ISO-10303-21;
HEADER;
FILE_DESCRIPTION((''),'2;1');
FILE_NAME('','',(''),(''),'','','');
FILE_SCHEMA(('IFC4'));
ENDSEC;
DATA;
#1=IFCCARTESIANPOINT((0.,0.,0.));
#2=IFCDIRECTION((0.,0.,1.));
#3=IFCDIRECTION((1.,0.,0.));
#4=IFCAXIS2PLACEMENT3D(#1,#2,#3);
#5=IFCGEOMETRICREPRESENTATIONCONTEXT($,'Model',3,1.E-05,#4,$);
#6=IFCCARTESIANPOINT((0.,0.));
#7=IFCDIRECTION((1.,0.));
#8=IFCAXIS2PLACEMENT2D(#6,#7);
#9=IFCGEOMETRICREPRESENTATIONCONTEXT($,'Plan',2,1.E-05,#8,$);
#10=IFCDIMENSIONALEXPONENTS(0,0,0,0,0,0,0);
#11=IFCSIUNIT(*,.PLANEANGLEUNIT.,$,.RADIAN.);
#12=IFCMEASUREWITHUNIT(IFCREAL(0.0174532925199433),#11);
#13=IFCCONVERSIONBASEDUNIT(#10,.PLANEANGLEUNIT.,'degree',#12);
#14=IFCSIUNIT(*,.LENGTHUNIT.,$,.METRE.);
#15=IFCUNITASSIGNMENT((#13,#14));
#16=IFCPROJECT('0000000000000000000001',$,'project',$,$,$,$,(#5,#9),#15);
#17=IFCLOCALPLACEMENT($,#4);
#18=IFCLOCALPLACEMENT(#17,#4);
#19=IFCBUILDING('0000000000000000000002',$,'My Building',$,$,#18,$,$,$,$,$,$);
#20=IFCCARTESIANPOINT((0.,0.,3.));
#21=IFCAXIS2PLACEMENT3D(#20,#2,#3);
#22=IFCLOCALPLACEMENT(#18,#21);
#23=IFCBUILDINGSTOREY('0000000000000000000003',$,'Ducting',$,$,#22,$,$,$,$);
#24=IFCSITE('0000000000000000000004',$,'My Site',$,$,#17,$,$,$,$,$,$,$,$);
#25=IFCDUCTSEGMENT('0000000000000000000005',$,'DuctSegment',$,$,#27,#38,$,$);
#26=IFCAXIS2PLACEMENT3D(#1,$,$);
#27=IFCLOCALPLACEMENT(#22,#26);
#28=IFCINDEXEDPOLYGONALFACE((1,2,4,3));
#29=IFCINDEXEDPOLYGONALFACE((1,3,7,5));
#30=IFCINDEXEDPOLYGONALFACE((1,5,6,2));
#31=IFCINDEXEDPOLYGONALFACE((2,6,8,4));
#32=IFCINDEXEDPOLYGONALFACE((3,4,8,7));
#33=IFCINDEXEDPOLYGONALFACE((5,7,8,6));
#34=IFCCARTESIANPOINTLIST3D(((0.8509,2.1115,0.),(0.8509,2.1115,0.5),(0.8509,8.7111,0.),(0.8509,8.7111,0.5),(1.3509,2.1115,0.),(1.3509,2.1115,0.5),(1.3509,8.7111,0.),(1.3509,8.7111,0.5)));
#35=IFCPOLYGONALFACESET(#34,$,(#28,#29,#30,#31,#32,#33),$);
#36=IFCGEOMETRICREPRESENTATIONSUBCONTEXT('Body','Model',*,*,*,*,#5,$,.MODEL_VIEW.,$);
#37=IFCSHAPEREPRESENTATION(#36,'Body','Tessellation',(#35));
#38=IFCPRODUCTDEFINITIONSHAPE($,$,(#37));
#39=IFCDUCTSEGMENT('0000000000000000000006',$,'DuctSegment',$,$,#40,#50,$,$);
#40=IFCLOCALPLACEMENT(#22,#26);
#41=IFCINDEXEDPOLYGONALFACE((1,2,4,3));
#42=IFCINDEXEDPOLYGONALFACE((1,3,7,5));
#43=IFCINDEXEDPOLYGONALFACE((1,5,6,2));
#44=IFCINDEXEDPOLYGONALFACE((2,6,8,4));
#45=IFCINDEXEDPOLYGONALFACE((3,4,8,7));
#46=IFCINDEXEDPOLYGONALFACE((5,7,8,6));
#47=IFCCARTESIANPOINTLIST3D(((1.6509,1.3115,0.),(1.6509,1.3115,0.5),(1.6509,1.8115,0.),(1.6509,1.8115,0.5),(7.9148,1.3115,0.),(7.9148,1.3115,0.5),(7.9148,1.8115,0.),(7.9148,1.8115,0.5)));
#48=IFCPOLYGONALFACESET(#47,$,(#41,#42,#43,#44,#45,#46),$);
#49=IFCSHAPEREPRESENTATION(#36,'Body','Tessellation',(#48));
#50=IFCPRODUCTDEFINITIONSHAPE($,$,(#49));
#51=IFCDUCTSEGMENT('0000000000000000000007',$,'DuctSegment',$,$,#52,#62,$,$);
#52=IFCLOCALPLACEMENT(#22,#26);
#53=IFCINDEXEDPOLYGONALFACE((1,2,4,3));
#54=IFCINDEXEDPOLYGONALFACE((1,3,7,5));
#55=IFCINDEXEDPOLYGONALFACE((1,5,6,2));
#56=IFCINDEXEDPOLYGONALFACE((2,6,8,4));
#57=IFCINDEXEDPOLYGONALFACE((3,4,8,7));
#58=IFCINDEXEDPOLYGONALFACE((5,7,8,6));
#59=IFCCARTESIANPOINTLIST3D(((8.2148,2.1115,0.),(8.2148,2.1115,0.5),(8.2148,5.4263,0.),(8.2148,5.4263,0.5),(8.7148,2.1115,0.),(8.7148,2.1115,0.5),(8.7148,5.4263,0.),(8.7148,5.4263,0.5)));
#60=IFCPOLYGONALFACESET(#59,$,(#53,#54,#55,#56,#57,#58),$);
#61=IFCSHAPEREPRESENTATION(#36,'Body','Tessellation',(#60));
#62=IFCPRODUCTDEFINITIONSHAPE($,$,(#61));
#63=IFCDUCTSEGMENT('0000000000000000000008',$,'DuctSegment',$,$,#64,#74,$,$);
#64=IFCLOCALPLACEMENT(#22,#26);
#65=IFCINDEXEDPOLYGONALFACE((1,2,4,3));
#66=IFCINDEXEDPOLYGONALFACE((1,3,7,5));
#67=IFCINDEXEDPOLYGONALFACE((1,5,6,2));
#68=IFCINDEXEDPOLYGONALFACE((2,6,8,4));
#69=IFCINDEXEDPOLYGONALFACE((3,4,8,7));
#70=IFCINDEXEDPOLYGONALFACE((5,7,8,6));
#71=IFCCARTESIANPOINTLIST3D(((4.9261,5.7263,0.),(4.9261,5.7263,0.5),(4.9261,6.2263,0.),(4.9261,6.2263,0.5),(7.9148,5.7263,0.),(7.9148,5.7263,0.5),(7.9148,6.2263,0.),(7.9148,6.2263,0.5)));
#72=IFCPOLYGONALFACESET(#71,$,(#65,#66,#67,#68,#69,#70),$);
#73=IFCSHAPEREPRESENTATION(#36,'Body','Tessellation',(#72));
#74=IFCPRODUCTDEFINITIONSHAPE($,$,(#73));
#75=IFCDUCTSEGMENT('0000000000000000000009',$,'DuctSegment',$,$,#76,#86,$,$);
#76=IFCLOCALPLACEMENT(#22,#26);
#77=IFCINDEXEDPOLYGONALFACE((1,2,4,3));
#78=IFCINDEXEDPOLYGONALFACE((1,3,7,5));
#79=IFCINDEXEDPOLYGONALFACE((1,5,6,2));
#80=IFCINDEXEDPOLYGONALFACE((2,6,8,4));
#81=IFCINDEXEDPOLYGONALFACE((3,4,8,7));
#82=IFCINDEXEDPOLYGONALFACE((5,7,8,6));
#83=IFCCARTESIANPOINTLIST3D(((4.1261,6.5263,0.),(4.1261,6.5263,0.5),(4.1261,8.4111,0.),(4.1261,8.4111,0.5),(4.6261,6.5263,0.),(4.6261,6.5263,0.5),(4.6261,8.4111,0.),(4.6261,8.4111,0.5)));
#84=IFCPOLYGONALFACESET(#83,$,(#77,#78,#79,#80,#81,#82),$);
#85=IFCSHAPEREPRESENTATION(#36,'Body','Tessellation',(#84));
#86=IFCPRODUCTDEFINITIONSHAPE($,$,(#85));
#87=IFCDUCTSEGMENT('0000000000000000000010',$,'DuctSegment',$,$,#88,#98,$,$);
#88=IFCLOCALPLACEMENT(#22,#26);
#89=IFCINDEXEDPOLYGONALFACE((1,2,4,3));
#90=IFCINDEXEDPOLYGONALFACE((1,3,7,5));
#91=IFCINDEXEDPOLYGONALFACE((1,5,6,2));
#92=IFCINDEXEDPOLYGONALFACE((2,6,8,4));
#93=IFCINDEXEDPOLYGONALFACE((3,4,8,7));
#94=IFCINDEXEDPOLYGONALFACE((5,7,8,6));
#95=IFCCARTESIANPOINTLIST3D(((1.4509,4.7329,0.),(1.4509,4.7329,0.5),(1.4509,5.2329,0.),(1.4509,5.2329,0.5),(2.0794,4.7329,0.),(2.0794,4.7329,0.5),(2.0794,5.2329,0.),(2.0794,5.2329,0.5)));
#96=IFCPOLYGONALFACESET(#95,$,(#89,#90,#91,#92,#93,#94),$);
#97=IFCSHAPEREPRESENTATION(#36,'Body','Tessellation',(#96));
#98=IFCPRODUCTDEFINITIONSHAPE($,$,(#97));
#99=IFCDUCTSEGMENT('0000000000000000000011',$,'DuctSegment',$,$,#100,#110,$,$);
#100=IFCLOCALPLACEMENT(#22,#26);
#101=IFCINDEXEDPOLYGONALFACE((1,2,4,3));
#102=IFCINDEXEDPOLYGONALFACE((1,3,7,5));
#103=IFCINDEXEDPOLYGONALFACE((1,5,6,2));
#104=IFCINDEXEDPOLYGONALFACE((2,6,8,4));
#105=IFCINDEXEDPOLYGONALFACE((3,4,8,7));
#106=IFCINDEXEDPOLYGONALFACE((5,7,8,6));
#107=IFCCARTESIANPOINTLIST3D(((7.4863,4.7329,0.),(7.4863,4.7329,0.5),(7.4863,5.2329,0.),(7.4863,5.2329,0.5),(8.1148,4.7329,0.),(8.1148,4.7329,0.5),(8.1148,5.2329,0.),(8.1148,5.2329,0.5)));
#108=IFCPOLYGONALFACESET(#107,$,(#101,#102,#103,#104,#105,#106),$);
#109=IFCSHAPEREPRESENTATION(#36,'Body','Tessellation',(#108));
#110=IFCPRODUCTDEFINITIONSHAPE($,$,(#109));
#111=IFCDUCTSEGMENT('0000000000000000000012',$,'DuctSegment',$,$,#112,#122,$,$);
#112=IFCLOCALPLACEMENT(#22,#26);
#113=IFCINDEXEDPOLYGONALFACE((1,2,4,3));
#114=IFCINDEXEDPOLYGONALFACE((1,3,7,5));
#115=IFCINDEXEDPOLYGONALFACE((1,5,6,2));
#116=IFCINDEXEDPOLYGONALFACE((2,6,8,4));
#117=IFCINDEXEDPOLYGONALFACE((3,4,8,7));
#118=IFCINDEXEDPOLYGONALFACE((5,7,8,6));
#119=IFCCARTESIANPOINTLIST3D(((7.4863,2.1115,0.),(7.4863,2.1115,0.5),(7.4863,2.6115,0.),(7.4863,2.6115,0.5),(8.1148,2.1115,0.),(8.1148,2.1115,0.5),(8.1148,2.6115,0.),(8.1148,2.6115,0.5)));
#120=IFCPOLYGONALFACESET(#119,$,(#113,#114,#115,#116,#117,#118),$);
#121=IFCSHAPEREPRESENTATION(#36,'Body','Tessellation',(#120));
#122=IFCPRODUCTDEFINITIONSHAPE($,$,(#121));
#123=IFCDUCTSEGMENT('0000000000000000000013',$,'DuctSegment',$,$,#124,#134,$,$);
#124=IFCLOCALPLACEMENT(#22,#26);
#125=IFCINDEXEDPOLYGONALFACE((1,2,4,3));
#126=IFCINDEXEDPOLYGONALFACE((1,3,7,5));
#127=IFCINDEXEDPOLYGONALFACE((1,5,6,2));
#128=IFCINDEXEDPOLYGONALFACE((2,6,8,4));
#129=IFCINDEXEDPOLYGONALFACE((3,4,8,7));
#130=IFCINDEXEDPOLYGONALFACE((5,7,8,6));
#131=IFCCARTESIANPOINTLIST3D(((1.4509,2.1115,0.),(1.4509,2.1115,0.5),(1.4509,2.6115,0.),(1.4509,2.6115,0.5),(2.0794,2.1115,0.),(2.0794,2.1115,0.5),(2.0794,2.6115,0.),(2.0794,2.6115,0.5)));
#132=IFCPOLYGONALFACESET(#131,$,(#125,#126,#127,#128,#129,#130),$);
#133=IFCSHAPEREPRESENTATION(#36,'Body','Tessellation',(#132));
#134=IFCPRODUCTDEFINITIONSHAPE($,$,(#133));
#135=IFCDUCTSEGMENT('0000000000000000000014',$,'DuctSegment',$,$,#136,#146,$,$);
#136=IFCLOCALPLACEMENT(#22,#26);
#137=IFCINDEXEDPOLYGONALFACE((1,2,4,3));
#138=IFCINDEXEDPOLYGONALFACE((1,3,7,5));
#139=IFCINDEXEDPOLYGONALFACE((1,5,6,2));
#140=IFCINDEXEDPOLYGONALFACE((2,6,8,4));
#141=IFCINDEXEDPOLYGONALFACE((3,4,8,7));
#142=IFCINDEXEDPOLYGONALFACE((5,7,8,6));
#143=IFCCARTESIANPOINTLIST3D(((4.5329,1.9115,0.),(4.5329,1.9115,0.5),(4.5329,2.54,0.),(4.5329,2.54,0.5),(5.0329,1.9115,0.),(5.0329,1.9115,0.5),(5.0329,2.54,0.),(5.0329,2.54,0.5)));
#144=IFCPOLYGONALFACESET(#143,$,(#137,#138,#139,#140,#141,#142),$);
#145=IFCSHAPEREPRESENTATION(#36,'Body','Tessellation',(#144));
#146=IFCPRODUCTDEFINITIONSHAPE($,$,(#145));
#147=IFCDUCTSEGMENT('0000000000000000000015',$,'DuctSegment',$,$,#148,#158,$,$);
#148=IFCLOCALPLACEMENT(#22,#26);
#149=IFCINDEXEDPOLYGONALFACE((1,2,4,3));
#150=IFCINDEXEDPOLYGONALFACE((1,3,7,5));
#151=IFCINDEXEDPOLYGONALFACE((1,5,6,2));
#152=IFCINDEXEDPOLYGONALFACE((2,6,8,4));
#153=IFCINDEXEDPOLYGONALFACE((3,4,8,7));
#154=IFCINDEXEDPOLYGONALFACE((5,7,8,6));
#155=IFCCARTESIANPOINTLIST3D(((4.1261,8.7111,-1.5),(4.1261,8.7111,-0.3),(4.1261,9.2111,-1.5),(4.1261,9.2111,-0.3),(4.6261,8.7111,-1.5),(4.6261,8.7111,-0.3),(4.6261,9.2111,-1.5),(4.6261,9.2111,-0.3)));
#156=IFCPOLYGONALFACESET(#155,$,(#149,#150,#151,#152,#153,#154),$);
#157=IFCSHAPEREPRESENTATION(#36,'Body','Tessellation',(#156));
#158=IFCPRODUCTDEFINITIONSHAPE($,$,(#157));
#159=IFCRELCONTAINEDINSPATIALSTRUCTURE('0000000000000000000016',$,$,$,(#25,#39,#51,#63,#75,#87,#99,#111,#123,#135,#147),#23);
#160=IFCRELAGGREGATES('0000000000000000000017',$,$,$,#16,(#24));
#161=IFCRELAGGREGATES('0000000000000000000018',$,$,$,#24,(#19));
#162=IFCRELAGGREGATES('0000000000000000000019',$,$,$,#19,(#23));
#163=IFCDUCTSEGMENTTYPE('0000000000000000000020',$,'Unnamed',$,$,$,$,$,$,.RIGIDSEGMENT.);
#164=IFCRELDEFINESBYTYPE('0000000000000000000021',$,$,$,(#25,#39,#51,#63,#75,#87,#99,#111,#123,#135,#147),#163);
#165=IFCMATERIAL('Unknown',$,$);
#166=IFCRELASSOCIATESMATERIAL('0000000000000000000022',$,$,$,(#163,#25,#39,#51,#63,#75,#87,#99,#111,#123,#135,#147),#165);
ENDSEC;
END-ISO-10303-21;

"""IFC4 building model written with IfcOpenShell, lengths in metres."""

from ifc_helpers import new_model, entity, si_unit, converted_unit, frame, origin_with_axes, origin_2d_with_axis, place, context, subcontext, project, spatial, rectangle, extrude, material, material_profile, profile_set, profile_usage, type_object, element, save


model = new_model("IFC4")

# Units and contexts
model_context = context("Model", 3, precision=1e-05, world=origin_with_axes())
plan_context = context("Plan", 2, precision=1e-05, world=origin_2d_with_axis())
body_context = subcontext(model_context, "Body", "Model", "MODEL_VIEW")
ifc_project = project(units=[converted_unit("PLANEANGLEUNIT", "degree", entity("IfcReal", 0.0174532925199433), si_unit("PLANEANGLEUNIT", "RADIAN"), dimensions=[0, 0, 0, 0, 0, 0, 0]), si_unit("LENGTHUNIT", "METRE")], contexts=[model_context, plan_context])

# Site, building, storey
site_placement = place(None, origin_with_axes())
site = spatial("IfcSite", under=ifc_project, at=site_placement, Name="My Site")
building_placement = place(site_placement, origin_with_axes())
building = spatial("IfcBuilding", under=site, at=building_placement, Name="My Building")
storey_placement = place(building_placement, frame((0.0, 0.0, 3.0), z_axis=(0.0, 0.0, 1.0), x_axis=(1.0, 0.0, 0.0)))
storey = spatial("IfcBuildingStorey", under=building, at=storey_placement, Name="Ducting")

# Duct segments
ifc_material = material(Name="Unknown")
ifc_material_profile_1 = material_profile(ifc_material, rectangle(XDim=0.5, YDim=0.5))
ifc_profile_set_1 = profile_set([ifc_material_profile_1])
ifc_profile_usage_1 = profile_usage(ifc_profile_set_1, cardinal=5)
duct_segment_type = type_object("IfcDuctSegmentType", Name="Unnamed", PredefinedType="RIGIDSEGMENT", material=ifc_profile_set_1)
duct_segment_1_placement = place(storey_placement, frame((1.1009, 8.7111, 0.25), z_axis=(0.0, -1.0, 0.0), x_axis=(1.0, 0.0, 0.0)))
element("IfcDuctSegment", 1, at=duct_segment_1_placement, inside=storey, type_object=duct_segment_type, material=ifc_profile_usage_1, Name="DuctSegment", context=body_context, shape_type="SweptSolid", body=[
    extrude(rectangle(XDim=0.5, YDim=0.5), origin_with_axes(), (0.0, 0.0, 1.0), 6.5996),
])
ifc_profile_usage_2 = profile_usage(ifc_profile_set_1, cardinal=5)
duct_segment_2_placement = place(storey_placement, frame((1.6509, 1.5615, 0.25), z_axis=(1.0, 0.0, 0.0), x_axis=(0.0, 1.0, 0.0)))
element("IfcDuctSegment", 2, at=duct_segment_2_placement, inside=storey, type_object=duct_segment_type, material=ifc_profile_usage_2, Name="DuctSegment", context=body_context, shape_type="SweptSolid", body=[
    extrude(rectangle(XDim=0.5, YDim=0.5), origin_with_axes(), (0.0, 0.0, 1.0), 6.264),
])
ifc_profile_usage_3 = profile_usage(ifc_profile_set_1, cardinal=5)
duct_segment_3_placement = place(storey_placement, frame((8.4648, 2.1115, 0.25), z_axis=(0.0, 1.0, 0.0), x_axis=(-1.0, 0.0, 0.0)))
element("IfcDuctSegment", 3, at=duct_segment_3_placement, inside=storey, type_object=duct_segment_type, material=ifc_profile_usage_3, Name="DuctSegment", context=body_context, shape_type="SweptSolid", body=[
    extrude(rectangle(XDim=0.5, YDim=0.5), origin_with_axes(), (0.0, 0.0, 1.0), 3.3147),
])
ifc_profile_usage_4 = profile_usage(ifc_profile_set_1, cardinal=5)
duct_segment_4_placement = place(storey_placement, frame((7.9148, 5.9763, 0.25), z_axis=(-1.0, 0.0, 0.0), x_axis=(0.0, -1.0, 0.0)))
element("IfcDuctSegment", 4, at=duct_segment_4_placement, inside=storey, type_object=duct_segment_type, material=ifc_profile_usage_4, Name="DuctSegment", context=body_context, shape_type="SweptSolid", body=[
    extrude(rectangle(XDim=0.5, YDim=0.5), origin_with_axes(), (0.0, 0.0, 1.0), 2.9887),
])
ifc_profile_usage_5 = profile_usage(ifc_profile_set_1, cardinal=5)
duct_segment_5_placement = place(storey_placement, frame((4.3761, 6.5263, 0.25), z_axis=(0.0, 1.0, 0.0), x_axis=(-1.0, 0.0, 0.0)))
element("IfcDuctSegment", 5, at=duct_segment_5_placement, inside=storey, type_object=duct_segment_type, material=ifc_profile_usage_5, Name="DuctSegment", context=body_context, shape_type="SweptSolid", body=[
    extrude(rectangle(XDim=0.5, YDim=0.5), origin_with_axes(), (0.0, 0.0, 1.0), 1.8849),
])
ifc_profile_usage_6 = profile_usage(ifc_profile_set_1, cardinal=5)
duct_segment_6_placement = place(storey_placement, frame((2.0794, 4.9829, 0.25), z_axis=(-1.0, 0.0, 0.0), x_axis=(0.0, -1.0, 0.0)))
element("IfcDuctSegment", 6, at=duct_segment_6_placement, inside=storey, type_object=duct_segment_type, material=ifc_profile_usage_6, Name="DuctSegment", context=body_context, shape_type="SweptSolid", body=[
    extrude(rectangle(XDim=0.5, YDim=0.5), origin_with_axes(), (0.0, 0.0, 1.0), 0.6285),
])
ifc_profile_usage_7 = profile_usage(ifc_profile_set_1, cardinal=5)
duct_segment_7_placement = place(storey_placement, frame((7.4863, 4.9829, 0.25), z_axis=(1.0, 0.0, 0.0), x_axis=(0.0, 1.0, 0.0)))
element("IfcDuctSegment", 7, at=duct_segment_7_placement, inside=storey, type_object=duct_segment_type, material=ifc_profile_usage_7, Name="DuctSegment", context=body_context, shape_type="SweptSolid", body=[
    extrude(rectangle(XDim=0.5, YDim=0.5), origin_with_axes(), (0.0, 0.0, 1.0), 0.6285),
])
ifc_profile_usage_8 = profile_usage(ifc_profile_set_1, cardinal=5)
duct_segment_8_placement = place(storey_placement, frame((7.4863, 2.3615, 0.25), z_axis=(1.0, 0.0, 0.0), x_axis=(0.0, 1.0, 0.0)))
element("IfcDuctSegment", 8, at=duct_segment_8_placement, inside=storey, type_object=duct_segment_type, material=ifc_profile_usage_8, Name="DuctSegment", context=body_context, shape_type="SweptSolid", body=[
    extrude(rectangle(XDim=0.5, YDim=0.5), origin_with_axes(), (0.0, 0.0, 1.0), 0.6285),
])
ifc_profile_usage_9 = profile_usage(ifc_profile_set_1, cardinal=5)
duct_segment_9_placement = place(storey_placement, frame((2.0794, 2.3615, 0.25), z_axis=(-1.0, 0.0, 0.0), x_axis=(0.0, -1.0, 0.0)))
element("IfcDuctSegment", 9, at=duct_segment_9_placement, inside=storey, type_object=duct_segment_type, material=ifc_profile_usage_9, Name="DuctSegment", context=body_context, shape_type="SweptSolid", body=[
    extrude(rectangle(XDim=0.5, YDim=0.5), origin_with_axes(), (0.0, 0.0, 1.0), 0.6285),
])
ifc_profile_usage_10 = profile_usage(ifc_profile_set_1, cardinal=5)
duct_segment_10_placement = place(storey_placement, frame((4.7829, 2.54, 0.25), z_axis=(0.0, -1.0, 0.0), x_axis=(1.0, 0.0, 0.0)))
element("IfcDuctSegment", 10, at=duct_segment_10_placement, inside=storey, type_object=duct_segment_type, material=ifc_profile_usage_10, Name="DuctSegment", context=body_context, shape_type="SweptSolid", body=[
    extrude(rectangle(XDim=0.5, YDim=0.5), origin_with_axes(), (0.0, 0.0, 1.0), 0.6285),
])
ifc_profile_usage_11 = profile_usage(ifc_profile_set_1, cardinal=5)
duct_segment_11_placement = place(storey_placement, frame((4.3761, 8.9611, -0.3), z_axis=(0.0, 0.0, -1.0), x_axis=(-1.0, 0.0, 0.0)))
element("IfcDuctSegment", 11, at=duct_segment_11_placement, inside=storey, type_object=duct_segment_type, material=ifc_profile_usage_11, Name="DuctSegment", context=body_context, shape_type="SweptSolid", body=[
    extrude(rectangle(XDim=0.5, YDim=0.5), origin_with_axes(), (0.0, 0.0, 1.0), 1.2),
])

save(model, "model.ifc")
